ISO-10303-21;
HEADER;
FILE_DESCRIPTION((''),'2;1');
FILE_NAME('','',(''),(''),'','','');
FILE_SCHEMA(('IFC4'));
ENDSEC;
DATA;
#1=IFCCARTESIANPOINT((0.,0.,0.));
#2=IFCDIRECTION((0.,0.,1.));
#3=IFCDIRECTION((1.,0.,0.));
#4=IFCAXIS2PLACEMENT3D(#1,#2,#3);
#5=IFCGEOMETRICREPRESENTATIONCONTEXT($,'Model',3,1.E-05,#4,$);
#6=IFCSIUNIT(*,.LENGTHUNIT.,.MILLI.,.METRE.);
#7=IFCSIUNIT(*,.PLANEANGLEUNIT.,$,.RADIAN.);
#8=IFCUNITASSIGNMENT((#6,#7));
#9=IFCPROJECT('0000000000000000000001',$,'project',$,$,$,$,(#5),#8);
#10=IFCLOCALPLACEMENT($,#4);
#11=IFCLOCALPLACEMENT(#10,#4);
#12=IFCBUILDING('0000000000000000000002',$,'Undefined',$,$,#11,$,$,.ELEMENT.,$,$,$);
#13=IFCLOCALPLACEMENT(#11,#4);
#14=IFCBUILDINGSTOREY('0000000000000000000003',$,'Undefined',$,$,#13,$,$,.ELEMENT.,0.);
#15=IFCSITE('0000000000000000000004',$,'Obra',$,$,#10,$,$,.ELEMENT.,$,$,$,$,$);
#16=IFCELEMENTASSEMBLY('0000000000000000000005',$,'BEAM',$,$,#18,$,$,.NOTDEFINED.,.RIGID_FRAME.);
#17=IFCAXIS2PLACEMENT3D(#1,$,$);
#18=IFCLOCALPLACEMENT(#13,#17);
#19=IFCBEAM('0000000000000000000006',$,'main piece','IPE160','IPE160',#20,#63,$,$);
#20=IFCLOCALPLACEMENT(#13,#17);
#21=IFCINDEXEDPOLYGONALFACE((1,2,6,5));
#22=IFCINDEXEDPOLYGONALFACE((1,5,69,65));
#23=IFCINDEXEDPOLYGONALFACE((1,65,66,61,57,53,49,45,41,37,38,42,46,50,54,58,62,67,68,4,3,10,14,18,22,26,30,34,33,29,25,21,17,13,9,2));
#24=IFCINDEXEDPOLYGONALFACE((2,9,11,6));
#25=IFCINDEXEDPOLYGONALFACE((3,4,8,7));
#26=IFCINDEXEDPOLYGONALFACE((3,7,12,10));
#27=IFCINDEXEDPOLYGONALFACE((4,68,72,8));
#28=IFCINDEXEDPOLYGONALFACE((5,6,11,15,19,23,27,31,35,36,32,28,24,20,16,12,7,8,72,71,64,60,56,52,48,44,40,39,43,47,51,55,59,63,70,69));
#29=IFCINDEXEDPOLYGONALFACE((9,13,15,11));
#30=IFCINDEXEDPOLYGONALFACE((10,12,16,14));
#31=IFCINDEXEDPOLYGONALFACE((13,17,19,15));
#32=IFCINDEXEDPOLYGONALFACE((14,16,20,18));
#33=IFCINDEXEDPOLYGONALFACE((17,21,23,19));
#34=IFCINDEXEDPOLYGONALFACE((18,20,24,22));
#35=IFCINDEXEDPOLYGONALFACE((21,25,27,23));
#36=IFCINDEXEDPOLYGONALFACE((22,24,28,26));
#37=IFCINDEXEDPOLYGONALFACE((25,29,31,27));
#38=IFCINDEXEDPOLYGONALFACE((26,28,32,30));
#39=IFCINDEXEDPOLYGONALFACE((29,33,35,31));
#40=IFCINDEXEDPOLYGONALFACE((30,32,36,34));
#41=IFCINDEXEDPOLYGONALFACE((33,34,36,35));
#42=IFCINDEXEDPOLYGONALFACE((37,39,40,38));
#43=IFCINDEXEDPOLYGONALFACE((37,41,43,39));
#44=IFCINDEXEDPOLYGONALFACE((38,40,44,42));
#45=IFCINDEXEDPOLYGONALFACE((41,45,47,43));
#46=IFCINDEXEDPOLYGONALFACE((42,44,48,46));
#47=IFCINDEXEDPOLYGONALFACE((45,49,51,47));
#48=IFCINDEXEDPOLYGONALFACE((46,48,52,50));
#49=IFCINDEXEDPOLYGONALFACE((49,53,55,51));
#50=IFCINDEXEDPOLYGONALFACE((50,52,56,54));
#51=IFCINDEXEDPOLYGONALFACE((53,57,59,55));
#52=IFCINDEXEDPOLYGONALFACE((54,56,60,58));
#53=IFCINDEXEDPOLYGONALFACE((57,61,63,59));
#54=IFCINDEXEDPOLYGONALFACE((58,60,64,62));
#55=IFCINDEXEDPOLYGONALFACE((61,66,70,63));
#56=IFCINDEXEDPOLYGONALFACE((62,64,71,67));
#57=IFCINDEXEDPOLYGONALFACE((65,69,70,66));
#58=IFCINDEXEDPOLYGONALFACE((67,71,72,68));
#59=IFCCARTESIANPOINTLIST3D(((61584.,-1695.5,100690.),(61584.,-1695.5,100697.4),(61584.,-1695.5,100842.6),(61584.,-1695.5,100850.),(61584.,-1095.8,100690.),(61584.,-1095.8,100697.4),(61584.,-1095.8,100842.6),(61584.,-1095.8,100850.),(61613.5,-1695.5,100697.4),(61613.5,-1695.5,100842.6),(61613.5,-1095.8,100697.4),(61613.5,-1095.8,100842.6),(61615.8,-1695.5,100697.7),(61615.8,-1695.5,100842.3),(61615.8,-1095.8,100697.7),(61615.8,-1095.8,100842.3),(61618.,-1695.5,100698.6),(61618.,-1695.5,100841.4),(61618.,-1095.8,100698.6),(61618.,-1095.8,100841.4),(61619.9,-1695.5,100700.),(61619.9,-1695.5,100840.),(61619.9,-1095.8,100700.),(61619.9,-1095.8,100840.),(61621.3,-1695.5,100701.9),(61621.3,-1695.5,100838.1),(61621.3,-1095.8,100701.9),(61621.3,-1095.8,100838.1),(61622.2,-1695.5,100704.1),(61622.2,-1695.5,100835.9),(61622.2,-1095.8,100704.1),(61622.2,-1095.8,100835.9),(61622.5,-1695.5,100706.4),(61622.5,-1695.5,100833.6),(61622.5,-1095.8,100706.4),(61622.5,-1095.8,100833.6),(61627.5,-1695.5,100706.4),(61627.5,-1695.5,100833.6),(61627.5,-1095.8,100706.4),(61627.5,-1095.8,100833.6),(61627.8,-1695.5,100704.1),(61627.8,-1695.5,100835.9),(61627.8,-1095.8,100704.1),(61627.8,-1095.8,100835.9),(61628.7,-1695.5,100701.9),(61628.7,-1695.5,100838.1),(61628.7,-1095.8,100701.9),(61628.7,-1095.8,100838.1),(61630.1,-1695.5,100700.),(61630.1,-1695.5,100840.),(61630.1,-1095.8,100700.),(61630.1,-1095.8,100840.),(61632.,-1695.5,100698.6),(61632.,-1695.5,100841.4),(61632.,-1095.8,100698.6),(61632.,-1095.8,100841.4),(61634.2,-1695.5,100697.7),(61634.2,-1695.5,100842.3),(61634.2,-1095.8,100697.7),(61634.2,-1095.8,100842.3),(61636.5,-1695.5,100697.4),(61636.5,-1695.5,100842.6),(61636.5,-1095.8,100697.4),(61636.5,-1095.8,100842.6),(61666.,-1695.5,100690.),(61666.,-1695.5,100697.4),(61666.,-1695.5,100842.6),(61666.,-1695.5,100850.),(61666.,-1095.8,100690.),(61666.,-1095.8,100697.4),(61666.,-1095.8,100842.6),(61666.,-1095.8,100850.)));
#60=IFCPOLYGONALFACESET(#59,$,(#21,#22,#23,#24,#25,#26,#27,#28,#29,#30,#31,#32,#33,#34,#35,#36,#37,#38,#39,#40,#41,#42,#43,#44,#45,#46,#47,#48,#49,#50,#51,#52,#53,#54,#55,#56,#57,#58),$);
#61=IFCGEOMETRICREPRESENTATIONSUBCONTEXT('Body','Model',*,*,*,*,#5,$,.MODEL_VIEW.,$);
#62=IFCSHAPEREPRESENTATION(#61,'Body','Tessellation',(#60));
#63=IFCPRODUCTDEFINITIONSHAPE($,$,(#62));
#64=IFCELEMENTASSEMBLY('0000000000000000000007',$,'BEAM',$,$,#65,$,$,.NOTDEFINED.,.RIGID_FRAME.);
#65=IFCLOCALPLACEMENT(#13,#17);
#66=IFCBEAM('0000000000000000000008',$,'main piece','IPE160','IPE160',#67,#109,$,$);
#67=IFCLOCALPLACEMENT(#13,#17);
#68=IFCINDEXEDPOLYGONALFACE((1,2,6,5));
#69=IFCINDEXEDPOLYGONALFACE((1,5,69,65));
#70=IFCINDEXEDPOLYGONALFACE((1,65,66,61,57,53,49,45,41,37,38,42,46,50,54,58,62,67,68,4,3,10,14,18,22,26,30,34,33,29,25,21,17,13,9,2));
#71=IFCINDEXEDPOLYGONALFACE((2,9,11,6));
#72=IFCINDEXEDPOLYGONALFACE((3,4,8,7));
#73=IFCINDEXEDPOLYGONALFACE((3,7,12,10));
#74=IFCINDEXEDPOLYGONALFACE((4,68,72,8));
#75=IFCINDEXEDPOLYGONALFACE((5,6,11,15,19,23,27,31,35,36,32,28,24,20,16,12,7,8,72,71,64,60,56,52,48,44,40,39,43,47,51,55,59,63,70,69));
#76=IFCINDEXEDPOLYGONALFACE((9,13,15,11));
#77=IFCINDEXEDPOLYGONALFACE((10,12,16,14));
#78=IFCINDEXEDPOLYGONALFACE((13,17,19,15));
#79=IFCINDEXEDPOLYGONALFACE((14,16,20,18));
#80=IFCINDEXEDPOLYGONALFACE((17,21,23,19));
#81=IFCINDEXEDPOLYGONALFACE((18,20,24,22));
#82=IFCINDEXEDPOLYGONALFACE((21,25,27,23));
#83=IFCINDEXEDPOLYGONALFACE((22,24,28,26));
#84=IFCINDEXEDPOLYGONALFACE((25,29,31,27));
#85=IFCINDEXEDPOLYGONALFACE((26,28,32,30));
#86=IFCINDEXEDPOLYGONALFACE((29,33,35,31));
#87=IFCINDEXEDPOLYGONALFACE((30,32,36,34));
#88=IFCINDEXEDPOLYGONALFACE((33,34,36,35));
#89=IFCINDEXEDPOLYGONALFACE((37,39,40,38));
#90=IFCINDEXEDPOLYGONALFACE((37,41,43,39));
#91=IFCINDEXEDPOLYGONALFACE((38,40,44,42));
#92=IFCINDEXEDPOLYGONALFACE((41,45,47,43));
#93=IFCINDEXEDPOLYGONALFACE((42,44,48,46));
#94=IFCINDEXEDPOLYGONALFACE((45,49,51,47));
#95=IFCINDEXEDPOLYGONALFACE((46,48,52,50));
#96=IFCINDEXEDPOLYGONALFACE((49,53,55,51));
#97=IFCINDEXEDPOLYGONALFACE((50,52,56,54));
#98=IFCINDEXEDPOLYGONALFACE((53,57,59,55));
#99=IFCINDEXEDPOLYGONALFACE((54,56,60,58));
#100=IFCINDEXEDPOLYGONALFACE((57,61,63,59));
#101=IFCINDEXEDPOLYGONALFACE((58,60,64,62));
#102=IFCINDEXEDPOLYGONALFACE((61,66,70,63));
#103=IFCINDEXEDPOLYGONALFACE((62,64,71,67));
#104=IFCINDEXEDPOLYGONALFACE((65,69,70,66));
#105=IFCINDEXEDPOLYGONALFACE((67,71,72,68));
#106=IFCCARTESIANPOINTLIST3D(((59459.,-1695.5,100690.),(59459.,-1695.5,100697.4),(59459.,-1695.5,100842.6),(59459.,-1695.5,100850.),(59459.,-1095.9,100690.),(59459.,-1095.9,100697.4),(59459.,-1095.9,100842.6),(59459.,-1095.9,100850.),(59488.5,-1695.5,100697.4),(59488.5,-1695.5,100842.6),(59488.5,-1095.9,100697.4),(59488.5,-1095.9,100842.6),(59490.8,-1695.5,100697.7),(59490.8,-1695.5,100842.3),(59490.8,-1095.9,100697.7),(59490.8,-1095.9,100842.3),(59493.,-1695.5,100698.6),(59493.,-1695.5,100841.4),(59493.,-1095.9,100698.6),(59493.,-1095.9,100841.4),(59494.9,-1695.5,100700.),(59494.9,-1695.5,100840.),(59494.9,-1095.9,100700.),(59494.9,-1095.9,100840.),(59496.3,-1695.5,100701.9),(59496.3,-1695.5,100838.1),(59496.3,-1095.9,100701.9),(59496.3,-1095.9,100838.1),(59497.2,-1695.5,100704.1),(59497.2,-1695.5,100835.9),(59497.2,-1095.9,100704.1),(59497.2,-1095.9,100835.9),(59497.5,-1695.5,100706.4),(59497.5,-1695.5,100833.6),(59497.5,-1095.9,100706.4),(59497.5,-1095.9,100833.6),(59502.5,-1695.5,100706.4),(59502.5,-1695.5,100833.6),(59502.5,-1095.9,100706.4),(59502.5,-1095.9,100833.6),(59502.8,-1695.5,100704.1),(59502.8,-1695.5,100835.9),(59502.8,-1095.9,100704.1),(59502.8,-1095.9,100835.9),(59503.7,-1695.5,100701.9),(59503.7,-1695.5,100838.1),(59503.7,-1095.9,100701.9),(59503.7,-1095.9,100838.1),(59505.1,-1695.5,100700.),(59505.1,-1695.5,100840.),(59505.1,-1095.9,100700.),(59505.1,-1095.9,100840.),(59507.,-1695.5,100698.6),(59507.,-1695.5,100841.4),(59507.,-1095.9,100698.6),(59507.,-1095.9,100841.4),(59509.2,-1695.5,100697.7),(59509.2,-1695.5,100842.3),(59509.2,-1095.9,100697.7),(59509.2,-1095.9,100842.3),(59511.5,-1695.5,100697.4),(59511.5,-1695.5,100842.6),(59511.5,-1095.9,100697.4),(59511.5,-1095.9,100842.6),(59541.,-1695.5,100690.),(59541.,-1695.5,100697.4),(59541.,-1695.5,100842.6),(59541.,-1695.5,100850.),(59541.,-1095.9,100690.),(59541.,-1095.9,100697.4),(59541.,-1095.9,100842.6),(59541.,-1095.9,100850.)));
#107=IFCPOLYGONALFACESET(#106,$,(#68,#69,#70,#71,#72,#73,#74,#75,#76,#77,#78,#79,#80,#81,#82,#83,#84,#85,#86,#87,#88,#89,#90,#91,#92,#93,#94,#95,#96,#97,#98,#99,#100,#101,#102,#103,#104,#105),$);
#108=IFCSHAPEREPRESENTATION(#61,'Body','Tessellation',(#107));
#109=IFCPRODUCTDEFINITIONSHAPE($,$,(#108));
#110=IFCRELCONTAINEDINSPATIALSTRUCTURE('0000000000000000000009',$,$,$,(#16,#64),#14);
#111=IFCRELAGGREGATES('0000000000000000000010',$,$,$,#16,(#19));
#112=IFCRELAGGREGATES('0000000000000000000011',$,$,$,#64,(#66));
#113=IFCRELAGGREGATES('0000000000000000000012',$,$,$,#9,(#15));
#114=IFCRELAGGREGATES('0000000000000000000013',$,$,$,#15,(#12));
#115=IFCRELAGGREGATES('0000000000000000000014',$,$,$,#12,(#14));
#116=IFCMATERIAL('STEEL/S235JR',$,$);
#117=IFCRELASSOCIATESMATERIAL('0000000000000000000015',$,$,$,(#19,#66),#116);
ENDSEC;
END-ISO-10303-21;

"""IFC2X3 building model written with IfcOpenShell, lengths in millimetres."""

from ifc_helpers import new_model, si_unit, frame, origin_with_axes, origin_2d_with_axis, place, context, subcontext, project, spatial, i_section, extrude, material, element, aggregate, save


model = new_model("IFC2X3")

# Units and contexts
model_context = context("Model", 3, precision=1e-05, world=origin_with_axes())
body_context = subcontext(model_context, "Body", "Model", "MODEL_VIEW")
ifc_project = project(units=[si_unit("LENGTHUNIT", "METRE", prefix="MILLI"), si_unit("PLANEANGLEUNIT", "RADIAN")], contexts=[model_context])

# Site, building, storey
site_placement = place(None, origin_with_axes())
site = spatial("IfcSite", under=ifc_project, at=site_placement, Name="Obra", CompositionType="ELEMENT")
building_placement = place(site_placement, origin_with_axes())
building = spatial("IfcBuilding", under=site, at=building_placement, Name="Undefined", CompositionType="ELEMENT")
storey_placement = place(building_placement, origin_with_axes())
storey = spatial("IfcBuildingStorey", under=building, at=storey_placement, Name="Undefined", CompositionType="ELEMENT", Elevation=0.0)

# Element assemblies, beams
ifc_material_1 = material(Name="STEEL/S235JR")
assembly_1_placement = place(storey_placement, origin_with_axes())
assembly_1 = element("IfcElementAssembly", 1, at=assembly_1_placement, inside=storey, Name="BEAM", AssemblyPlace="NOTDEFINED", PredefinedType="RIGID_FRAME")
beam_1_placement = place(assembly_1_placement, frame((61625.0, -1095.8, 100770.0), z_axis=(0.0, 0.0, 1.0), x_axis=(0.0, -1.0, 0.0)))
beam_1 = element("IfcBeam", 2, at=beam_1_placement, material=ifc_material_1, Name="main piece", Description="IPE160", ObjectType="IPE160", context=body_context, shape_type="SweptSolid", body=[
    extrude(i_section(OverallWidth=82.0, OverallDepth=160.0, WebThickness=5.0, FlangeThickness=7.4, FilletRadius=9.0, at=origin_2d_with_axis()), frame((599.7, 0.0, 0.0), z_axis=(-1.0, 0.0, 0.0), x_axis=(0.0, -1.0, 0.0)), (0.0, 0.0, 1.0), 599.7),
])
aggregate(assembly_1, [beam_1])
assembly_2_placement = place(storey_placement, origin_with_axes())
assembly_2 = element("IfcElementAssembly", 3, at=assembly_2_placement, inside=storey, Name="BEAM", AssemblyPlace="NOTDEFINED", PredefinedType="RIGID_FRAME")
beam_2_placement = place(assembly_2_placement, frame((59500.0, -1095.9, 100770.0), z_axis=(0.0, 0.0, 1.0), x_axis=(0.0, -1.0, 0.0)))
beam_2 = element("IfcBeam", 4, at=beam_2_placement, material=ifc_material_1, Name="main piece", Description="IPE160", ObjectType="IPE160", context=body_context, shape_type="SweptSolid", body=[
    extrude(i_section(OverallWidth=82.0, OverallDepth=160.0, WebThickness=5.0, FlangeThickness=7.4, FilletRadius=9.0, at=origin_2d_with_axis()), frame((599.6, 0.0, 0.0), z_axis=(-1.0, 0.0, 0.0), x_axis=(0.0, -1.0, 0.0)), (0.0, 0.0, 1.0), 599.6),
])
aggregate(assembly_2, [beam_2])

save(model, "model.ifc")
